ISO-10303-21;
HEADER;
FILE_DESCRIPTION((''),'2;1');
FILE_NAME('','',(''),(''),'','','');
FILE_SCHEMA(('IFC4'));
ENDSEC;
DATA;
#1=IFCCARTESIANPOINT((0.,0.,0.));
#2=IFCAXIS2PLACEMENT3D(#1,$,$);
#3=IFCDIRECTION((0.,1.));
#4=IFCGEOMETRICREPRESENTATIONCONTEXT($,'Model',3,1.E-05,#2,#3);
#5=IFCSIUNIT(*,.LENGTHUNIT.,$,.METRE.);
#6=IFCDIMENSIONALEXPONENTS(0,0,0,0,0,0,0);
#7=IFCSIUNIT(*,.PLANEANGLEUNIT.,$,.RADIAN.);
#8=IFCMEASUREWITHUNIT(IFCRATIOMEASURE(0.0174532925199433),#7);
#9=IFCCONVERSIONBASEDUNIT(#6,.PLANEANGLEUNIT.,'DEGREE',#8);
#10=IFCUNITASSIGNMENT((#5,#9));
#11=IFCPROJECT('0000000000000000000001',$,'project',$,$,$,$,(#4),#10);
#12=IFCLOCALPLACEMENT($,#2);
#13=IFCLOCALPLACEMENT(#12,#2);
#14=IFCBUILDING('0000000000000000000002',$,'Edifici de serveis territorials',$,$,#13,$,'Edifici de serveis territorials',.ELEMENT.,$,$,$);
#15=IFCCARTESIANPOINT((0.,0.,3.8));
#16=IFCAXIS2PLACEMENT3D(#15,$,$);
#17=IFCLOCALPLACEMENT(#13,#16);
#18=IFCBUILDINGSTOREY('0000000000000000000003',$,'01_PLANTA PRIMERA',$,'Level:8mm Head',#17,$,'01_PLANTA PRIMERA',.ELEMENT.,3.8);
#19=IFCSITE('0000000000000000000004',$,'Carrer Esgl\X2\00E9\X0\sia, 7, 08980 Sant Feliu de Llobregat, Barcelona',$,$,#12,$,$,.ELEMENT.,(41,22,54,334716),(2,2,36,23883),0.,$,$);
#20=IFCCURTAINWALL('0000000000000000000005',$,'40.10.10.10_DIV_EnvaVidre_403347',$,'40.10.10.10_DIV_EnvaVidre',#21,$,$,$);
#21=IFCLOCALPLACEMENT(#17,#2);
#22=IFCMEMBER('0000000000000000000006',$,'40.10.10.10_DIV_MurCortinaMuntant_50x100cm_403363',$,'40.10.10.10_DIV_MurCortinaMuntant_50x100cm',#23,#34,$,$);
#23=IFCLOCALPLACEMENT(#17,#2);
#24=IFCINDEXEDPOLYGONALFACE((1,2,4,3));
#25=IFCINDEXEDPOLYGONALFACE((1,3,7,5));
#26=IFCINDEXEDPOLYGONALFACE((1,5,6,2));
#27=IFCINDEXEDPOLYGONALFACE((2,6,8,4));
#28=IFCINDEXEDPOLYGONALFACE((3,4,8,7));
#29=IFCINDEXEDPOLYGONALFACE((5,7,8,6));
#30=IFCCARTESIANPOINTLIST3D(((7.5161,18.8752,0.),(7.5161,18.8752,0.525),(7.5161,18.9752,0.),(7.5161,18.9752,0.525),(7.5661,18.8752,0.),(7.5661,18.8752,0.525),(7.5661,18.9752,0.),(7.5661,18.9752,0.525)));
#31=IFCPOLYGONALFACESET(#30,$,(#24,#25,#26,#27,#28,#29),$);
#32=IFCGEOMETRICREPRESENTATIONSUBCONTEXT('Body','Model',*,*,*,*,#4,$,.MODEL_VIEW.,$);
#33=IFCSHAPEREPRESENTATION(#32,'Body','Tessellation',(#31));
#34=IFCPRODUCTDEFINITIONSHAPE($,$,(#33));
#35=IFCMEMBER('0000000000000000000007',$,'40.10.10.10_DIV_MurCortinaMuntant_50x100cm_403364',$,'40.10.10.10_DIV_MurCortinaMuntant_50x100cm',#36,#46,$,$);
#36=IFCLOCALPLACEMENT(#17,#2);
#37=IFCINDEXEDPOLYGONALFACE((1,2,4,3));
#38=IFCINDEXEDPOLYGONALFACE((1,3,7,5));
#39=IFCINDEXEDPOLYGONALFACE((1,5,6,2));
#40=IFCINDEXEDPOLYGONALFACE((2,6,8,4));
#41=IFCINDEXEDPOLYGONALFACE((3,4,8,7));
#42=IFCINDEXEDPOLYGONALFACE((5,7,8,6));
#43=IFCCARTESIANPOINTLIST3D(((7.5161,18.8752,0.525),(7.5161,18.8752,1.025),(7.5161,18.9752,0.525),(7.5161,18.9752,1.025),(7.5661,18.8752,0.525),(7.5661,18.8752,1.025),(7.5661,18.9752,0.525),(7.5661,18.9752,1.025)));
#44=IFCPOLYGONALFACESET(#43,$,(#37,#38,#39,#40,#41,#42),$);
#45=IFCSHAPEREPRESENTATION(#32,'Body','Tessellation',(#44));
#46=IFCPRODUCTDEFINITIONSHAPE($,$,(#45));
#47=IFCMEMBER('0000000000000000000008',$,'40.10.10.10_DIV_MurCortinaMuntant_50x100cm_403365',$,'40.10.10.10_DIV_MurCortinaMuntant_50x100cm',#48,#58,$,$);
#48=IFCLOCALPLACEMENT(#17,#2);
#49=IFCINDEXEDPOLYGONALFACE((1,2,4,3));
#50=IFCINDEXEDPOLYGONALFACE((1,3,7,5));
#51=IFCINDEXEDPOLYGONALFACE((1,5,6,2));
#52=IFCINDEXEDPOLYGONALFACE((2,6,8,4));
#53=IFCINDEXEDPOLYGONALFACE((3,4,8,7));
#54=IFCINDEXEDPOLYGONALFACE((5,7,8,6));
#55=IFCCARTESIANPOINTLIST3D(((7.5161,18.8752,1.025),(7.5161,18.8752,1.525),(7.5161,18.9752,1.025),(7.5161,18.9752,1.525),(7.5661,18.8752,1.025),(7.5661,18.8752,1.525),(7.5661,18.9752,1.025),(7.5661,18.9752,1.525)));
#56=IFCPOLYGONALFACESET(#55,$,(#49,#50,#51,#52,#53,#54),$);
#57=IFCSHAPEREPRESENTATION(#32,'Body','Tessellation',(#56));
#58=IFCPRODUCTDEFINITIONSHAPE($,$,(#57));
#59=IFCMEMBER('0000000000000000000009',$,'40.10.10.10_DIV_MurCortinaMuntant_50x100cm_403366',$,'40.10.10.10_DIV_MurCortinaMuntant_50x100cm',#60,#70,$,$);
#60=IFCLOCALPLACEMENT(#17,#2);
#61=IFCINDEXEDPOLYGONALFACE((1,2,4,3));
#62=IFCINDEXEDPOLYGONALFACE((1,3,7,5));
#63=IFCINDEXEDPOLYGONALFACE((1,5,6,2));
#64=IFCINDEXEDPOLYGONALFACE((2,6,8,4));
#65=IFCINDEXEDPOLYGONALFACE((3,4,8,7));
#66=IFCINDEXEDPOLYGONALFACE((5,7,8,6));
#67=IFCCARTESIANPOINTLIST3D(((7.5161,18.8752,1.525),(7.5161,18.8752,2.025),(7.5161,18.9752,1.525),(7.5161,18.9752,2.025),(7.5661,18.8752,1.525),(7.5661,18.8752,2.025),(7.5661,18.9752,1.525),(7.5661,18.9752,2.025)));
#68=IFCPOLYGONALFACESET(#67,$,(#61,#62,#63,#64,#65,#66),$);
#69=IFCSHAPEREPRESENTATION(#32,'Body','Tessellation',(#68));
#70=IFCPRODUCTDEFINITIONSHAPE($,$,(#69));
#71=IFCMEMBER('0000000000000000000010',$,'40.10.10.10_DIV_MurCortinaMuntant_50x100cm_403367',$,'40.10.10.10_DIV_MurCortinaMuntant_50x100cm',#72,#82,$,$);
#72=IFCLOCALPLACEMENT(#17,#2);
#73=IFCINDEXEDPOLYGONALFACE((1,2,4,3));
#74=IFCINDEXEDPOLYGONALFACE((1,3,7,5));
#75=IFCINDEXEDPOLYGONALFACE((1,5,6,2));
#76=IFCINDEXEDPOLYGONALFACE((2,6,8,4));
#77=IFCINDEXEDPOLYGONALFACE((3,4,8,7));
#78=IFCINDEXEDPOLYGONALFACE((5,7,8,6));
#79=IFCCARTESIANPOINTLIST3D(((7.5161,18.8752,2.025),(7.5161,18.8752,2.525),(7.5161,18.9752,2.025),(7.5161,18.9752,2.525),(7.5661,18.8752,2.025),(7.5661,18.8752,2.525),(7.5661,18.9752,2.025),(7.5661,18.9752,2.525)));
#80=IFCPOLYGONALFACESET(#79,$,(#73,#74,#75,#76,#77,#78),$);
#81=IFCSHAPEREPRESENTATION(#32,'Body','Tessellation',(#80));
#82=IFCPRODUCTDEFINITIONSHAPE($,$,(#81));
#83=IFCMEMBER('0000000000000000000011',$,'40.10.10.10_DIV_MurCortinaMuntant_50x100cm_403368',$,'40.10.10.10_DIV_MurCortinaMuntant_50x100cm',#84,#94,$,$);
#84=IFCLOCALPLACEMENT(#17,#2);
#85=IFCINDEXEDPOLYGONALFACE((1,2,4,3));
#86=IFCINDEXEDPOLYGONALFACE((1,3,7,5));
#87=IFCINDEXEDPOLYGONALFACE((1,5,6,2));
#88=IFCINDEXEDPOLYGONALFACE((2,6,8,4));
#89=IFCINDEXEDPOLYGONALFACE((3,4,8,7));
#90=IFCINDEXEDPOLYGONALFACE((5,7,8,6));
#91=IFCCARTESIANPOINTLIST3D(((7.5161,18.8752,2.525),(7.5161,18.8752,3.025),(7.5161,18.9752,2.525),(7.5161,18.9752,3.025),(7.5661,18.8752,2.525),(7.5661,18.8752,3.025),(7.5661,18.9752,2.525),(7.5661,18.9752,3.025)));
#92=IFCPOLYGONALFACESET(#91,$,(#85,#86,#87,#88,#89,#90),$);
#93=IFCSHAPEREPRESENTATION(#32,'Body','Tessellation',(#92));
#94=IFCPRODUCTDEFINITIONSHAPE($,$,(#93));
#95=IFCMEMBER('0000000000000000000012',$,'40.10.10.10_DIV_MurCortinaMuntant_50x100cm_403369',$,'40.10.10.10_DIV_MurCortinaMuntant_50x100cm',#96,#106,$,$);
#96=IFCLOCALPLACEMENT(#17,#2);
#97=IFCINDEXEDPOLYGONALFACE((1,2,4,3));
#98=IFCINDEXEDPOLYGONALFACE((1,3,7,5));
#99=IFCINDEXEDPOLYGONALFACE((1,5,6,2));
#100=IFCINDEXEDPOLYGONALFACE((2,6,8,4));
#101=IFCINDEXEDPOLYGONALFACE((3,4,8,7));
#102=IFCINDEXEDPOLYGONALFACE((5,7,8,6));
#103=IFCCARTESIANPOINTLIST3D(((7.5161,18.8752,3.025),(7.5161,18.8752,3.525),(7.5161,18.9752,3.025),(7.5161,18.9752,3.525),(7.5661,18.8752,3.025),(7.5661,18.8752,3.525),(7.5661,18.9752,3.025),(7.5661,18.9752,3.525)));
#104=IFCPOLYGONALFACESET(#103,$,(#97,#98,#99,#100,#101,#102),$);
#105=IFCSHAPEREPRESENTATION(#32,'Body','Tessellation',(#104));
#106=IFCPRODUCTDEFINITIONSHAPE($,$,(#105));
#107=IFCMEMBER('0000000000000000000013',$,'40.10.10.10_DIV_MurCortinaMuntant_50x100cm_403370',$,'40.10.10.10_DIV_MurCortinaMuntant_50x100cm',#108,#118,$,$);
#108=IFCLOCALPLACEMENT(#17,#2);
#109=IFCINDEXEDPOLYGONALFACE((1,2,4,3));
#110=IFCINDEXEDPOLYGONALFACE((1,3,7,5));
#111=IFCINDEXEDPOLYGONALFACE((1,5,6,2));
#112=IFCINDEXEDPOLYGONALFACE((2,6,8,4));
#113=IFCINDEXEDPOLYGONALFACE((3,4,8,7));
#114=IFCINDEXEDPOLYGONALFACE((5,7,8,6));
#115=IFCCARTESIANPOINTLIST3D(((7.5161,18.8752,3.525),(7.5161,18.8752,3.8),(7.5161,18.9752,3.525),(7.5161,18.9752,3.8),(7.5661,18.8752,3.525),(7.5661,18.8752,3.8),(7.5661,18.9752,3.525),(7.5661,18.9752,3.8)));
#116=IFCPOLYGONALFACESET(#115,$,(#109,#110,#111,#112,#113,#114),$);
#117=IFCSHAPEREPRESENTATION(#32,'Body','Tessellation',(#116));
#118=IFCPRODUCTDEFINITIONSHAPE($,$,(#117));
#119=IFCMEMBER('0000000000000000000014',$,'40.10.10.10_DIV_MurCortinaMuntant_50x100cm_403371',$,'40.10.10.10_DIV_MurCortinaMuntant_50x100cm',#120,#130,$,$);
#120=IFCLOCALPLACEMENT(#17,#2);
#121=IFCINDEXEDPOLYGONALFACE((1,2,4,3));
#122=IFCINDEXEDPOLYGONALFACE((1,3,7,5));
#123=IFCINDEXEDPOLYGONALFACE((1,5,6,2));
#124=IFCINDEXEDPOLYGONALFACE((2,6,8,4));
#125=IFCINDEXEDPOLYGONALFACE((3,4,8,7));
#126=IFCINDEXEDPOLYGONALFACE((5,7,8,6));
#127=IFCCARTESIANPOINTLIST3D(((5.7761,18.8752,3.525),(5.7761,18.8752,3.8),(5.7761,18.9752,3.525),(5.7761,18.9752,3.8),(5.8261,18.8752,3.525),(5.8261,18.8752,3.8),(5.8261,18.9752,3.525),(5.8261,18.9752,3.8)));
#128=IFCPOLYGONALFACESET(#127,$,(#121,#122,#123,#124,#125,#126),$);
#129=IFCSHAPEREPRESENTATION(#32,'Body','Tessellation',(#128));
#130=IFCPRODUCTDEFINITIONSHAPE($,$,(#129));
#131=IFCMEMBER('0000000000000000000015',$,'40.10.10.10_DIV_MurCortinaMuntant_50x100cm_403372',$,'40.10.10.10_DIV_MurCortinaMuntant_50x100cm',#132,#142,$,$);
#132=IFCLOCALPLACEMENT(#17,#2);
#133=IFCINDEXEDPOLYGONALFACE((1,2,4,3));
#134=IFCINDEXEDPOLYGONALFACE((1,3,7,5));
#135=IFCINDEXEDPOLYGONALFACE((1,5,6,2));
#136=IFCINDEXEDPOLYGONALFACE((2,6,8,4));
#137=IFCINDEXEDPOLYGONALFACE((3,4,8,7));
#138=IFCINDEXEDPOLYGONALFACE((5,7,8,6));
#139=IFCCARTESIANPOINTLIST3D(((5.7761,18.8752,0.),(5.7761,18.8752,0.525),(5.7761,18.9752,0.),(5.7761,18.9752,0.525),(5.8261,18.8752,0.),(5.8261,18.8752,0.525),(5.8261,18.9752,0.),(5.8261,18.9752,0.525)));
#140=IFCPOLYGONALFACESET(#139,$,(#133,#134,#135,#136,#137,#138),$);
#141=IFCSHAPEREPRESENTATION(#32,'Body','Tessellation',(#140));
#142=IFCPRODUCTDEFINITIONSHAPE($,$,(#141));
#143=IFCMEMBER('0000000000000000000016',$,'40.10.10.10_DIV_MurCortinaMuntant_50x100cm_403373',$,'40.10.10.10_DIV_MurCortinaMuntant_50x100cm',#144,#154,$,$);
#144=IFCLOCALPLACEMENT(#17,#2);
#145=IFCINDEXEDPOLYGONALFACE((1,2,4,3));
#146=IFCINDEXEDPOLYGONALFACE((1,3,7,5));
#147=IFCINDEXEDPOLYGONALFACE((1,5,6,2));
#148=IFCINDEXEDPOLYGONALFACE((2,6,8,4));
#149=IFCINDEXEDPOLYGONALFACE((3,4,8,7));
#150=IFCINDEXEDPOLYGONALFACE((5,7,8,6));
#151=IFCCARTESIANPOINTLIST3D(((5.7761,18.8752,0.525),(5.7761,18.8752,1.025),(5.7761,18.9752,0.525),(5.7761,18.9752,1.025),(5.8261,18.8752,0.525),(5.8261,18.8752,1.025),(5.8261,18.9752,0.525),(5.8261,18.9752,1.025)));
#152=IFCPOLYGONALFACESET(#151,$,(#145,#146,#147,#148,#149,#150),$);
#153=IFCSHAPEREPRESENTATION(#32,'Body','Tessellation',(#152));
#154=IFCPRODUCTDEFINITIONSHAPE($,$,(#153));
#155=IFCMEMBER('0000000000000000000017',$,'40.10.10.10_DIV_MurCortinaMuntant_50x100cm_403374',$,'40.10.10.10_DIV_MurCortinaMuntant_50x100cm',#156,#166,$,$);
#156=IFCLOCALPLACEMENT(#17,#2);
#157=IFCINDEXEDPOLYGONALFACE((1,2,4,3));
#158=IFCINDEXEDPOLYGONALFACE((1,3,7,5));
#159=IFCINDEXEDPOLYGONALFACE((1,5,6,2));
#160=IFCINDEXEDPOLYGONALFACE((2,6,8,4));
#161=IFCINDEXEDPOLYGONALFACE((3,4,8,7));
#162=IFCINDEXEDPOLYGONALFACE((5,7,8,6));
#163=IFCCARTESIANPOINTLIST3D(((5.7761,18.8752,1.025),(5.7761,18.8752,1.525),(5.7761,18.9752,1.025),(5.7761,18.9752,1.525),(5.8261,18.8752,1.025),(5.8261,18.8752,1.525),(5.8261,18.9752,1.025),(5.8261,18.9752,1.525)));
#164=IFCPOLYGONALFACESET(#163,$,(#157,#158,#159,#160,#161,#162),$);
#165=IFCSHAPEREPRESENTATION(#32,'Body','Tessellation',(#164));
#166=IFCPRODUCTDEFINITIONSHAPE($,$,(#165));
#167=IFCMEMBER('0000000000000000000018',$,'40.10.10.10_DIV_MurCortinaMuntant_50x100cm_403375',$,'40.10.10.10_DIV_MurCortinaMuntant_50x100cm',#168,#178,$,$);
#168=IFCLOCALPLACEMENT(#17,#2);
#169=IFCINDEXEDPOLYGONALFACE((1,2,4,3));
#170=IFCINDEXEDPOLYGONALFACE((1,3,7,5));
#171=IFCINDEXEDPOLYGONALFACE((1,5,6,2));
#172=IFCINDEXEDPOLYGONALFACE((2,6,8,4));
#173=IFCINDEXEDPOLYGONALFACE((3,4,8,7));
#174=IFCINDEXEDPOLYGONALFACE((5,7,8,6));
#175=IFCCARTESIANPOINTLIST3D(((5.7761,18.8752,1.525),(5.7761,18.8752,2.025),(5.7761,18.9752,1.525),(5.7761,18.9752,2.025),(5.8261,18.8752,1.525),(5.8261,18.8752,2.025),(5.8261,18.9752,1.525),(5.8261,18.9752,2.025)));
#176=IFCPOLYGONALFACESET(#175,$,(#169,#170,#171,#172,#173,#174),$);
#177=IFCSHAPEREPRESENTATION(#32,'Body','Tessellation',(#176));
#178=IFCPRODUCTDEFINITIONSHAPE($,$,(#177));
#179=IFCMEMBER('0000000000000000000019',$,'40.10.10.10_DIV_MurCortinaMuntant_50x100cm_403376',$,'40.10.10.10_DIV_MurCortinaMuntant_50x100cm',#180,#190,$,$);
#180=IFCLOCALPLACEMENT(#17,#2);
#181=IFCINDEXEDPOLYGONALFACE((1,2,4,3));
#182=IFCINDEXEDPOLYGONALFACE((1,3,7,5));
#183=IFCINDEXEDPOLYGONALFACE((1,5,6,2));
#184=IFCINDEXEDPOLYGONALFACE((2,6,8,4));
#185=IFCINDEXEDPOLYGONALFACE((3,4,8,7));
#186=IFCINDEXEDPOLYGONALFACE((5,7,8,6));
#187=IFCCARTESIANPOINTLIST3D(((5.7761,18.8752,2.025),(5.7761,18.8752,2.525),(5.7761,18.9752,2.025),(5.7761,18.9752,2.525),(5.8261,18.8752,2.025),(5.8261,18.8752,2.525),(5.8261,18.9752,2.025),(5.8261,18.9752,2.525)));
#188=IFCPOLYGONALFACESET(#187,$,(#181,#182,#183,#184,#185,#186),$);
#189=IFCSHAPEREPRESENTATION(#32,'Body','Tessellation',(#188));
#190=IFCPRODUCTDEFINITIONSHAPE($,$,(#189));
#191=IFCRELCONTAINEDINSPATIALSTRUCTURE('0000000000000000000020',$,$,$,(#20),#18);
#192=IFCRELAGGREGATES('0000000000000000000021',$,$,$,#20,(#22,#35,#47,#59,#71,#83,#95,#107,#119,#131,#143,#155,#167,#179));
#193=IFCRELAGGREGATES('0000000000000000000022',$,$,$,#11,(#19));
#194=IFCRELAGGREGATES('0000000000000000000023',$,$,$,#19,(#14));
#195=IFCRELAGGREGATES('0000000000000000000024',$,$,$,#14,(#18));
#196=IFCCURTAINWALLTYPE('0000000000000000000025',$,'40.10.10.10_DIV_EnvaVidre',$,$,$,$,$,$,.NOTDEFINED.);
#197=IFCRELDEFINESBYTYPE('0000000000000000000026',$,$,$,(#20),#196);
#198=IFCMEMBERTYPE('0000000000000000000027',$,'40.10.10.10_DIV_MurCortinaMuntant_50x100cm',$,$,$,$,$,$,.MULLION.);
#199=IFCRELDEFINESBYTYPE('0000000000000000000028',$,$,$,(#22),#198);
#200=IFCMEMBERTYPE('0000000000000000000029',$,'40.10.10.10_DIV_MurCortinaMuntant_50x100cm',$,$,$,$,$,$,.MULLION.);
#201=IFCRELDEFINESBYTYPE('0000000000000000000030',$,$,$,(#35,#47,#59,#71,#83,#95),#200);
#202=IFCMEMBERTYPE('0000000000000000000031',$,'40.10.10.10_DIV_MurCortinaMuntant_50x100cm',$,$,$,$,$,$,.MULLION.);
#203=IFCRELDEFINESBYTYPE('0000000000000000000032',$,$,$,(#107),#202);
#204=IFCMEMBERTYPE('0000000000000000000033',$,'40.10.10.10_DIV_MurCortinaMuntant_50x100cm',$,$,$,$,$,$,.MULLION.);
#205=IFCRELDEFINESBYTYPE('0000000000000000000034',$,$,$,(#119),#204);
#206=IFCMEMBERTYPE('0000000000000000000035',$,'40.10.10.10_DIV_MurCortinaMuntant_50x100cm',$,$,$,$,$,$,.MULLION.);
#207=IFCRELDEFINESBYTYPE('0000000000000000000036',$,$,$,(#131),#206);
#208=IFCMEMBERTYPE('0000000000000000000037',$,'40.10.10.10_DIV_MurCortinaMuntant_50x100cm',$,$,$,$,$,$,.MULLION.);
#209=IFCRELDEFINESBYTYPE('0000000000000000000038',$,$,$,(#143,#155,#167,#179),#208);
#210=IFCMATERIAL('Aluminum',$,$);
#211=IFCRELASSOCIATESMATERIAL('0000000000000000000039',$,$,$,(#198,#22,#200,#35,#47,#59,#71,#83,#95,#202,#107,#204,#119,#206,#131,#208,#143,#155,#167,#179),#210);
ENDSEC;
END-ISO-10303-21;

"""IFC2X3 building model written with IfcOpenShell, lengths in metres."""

from ifc_helpers import new_model, entity, si_unit, converted_unit, direction, frame, origin, origin_2d_with_axis, place, context, subcontext, project, spatial, rectangle, extrude, source, transform, mapped, material, type_object, type_shapes, element, aggregate, save


model = new_model("IFC2X3")

# Units and contexts
model_context = context("Model", 3, precision=1e-05, world=origin(), true_north=direction((0.0, 1.0)))
body_context = subcontext(model_context, "Body", "Model", "MODEL_VIEW")
ifc_project = project(units=[si_unit("LENGTHUNIT", "METRE"), converted_unit("PLANEANGLEUNIT", "DEGREE", entity("IfcRatioMeasure", 0.0174532925199433), si_unit("PLANEANGLEUNIT", "RADIAN"), dimensions=[0, 0, 0, 0, 0, 0, 0])], contexts=[model_context])

# Site, building, storey
site_placement = place(None, origin())
site = spatial("IfcSite", under=ifc_project, at=site_placement, Name="Carrer Església, 7, 08980 Sant Feliu de Llobregat, Barcelona", CompositionType="ELEMENT", RefLatitude=(41, 22, 54, 334716), RefLongitude=(2, 2, 36, 23883), RefElevation=0.0)
building_placement = place(site_placement, origin())
building = spatial("IfcBuilding", under=site, at=building_placement, Name="Edifici de serveis territorials", LongName="Edifici de serveis territorials", CompositionType="ELEMENT")
storey_placement = place(building_placement, frame((0.0, 0.0, 3.8)))
storey = spatial("IfcBuildingStorey", under=building, at=storey_placement, Name="01_PLANTA PRIMERA", ObjectType="Level:8mm Head", LongName="01_PLANTA PRIMERA", CompositionType="ELEMENT", Elevation=3.8)

# Curtain wall, members
curtain_wall_type = type_object("IfcCurtainWallType", Name="40.10.10.10_DIV_EnvaVidre", PredefinedType="NOTDEFINED")
curtain_wall_1_placement = place(storey_placement, frame((0.0, 0.0, -3.8)))
curtain_wall_1 = element("IfcCurtainWall", 1, at=curtain_wall_1_placement, inside=storey, type_object=curtain_wall_type, Name="40.10.10.10_DIV_EnvaVidre_403347", ObjectType="40.10.10.10_DIV_EnvaVidre")
ifc_material_1 = material(Name="Aluminum")
member_type_1 = type_object("IfcMemberType", Name="40.10.10.10_DIV_MurCortinaMuntant_50x100cm", PredefinedType="MULLION", material=ifc_material_1)
shared_shape_1 = source(origin(), body_context, "Body", "SweptSolid", [
    extrude(rectangle(XDim=0.1, YDim=0.05, at=origin_2d_with_axis()), frame((-0.025, 0.0, -0.525), z_axis=(0.0, 0.0, 1.0), x_axis=(0.0, -1.0, 0.0)), (0.0, 0.0, 1.0), 0.525),
])
type_shapes(member_type_1, [shared_shape_1])
member_1_placement = place(storey_placement, frame((7.5661, 18.9252, 0.0), z_axis=(0.0, 0.0, -1.0), x_axis=(1.0, 0.0, 0.0)))
member_1 = element("IfcMember", 2, at=member_1_placement, type_object=member_type_1, material=ifc_material_1, Name="40.10.10.10_DIV_MurCortinaMuntant_50x100cm_403363", ObjectType="40.10.10.10_DIV_MurCortinaMuntant_50x100cm", context=body_context, shape_type="MappedRepresentation", body=[
    mapped(shared_shape_1, transform((0.0, 0.0, 0.0), scale=1.0)),
])
member_type_2 = type_object("IfcMemberType", Name="40.10.10.10_DIV_MurCortinaMuntant_50x100cm", PredefinedType="MULLION", material=ifc_material_1)
shared_shape_2 = source(origin(), body_context, "Body", "SweptSolid", [
    extrude(rectangle(XDim=0.1, YDim=0.05, at=origin_2d_with_axis()), frame((-0.025, 0.0, -0.5), z_axis=(0.0, 0.0, 1.0), x_axis=(0.0, -1.0, 0.0)), (0.0, 0.0, 1.0), 0.5),
])
type_shapes(member_type_2, [shared_shape_2])
member_2_placement = place(storey_placement, frame((7.5661, 18.9252, 0.525), z_axis=(0.0, 0.0, -1.0), x_axis=(1.0, 0.0, 0.0)))
member_2 = element("IfcMember", 3, at=member_2_placement, type_object=member_type_2, material=ifc_material_1, Name="40.10.10.10_DIV_MurCortinaMuntant_50x100cm_403364", ObjectType="40.10.10.10_DIV_MurCortinaMuntant_50x100cm", context=body_context, shape_type="MappedRepresentation", body=[
    mapped(shared_shape_2, transform((0.0, 0.0, 0.0), scale=1.0)),
])
member_3_placement = place(storey_placement, frame((7.5661, 18.9252, 1.025), z_axis=(0.0, 0.0, -1.0), x_axis=(1.0, 0.0, 0.0)))
member_3 = element("IfcMember", 4, at=member_3_placement, type_object=member_type_2, material=ifc_material_1, Name="40.10.10.10_DIV_MurCortinaMuntant_50x100cm_403365", ObjectType="40.10.10.10_DIV_MurCortinaMuntant_50x100cm", context=body_context, shape_type="MappedRepresentation", body=[
    mapped(shared_shape_2, transform((0.0, 0.0, 0.0), scale=1.0)),
])
member_4_placement = place(storey_placement, frame((7.5661, 18.9252, 1.525), z_axis=(0.0, 0.0, -1.0), x_axis=(1.0, 0.0, 0.0)))
member_4 = element("IfcMember", 5, at=member_4_placement, type_object=member_type_2, material=ifc_material_1, Name="40.10.10.10_DIV_MurCortinaMuntant_50x100cm_403366", ObjectType="40.10.10.10_DIV_MurCortinaMuntant_50x100cm", context=body_context, shape_type="MappedRepresentation", body=[
    mapped(shared_shape_2, transform((0.0, 0.0, 0.0), scale=1.0)),
])
member_5_placement = place(storey_placement, frame((7.5661, 18.9252, 2.025), z_axis=(0.0, 0.0, -1.0), x_axis=(1.0, 0.0, 0.0)))
member_5 = element("IfcMember", 6, at=member_5_placement, type_object=member_type_2, material=ifc_material_1, Name="40.10.10.10_DIV_MurCortinaMuntant_50x100cm_403367", ObjectType="40.10.10.10_DIV_MurCortinaMuntant_50x100cm", context=body_context, shape_type="MappedRepresentation", body=[
    mapped(shared_shape_2, transform((0.0, 0.0, 0.0), scale=1.0)),
])
member_6_placement = place(storey_placement, frame((7.5661, 18.9252, 2.525), z_axis=(0.0, 0.0, -1.0), x_axis=(1.0, 0.0, 0.0)))
member_6 = element("IfcMember", 7, at=member_6_placement, type_object=member_type_2, material=ifc_material_1, Name="40.10.10.10_DIV_MurCortinaMuntant_50x100cm_403368", ObjectType="40.10.10.10_DIV_MurCortinaMuntant_50x100cm", context=body_context, shape_type="MappedRepresentation", body=[
    mapped(shared_shape_2, transform((0.0, 0.0, 0.0), scale=1.0)),
])
member_7_placement = place(storey_placement, frame((7.5661, 18.9252, 3.025), z_axis=(0.0, 0.0, -1.0), x_axis=(1.0, 0.0, 0.0)))
member_7 = element("IfcMember", 8, at=member_7_placement, type_object=member_type_2, material=ifc_material_1, Name="40.10.10.10_DIV_MurCortinaMuntant_50x100cm_403369", ObjectType="40.10.10.10_DIV_MurCortinaMuntant_50x100cm", context=body_context, shape_type="MappedRepresentation", body=[
    mapped(shared_shape_2, transform((0.0, 0.0, 0.0), scale=1.0)),
])
member_type_3 = type_object("IfcMemberType", Name="40.10.10.10_DIV_MurCortinaMuntant_50x100cm", PredefinedType="MULLION", material=ifc_material_1)
shared_shape_3 = source(origin(), body_context, "Body", "SweptSolid", [
    extrude(rectangle(XDim=0.1, YDim=0.05, at=origin_2d_with_axis()), frame((-0.025, 0.0, -0.275), z_axis=(0.0, 0.0, 1.0), x_axis=(0.0, -1.0, 0.0)), (0.0, 0.0, 1.0), 0.275),
])
type_shapes(member_type_3, [shared_shape_3])
member_8_placement = place(storey_placement, frame((7.5661, 18.9252, 3.525), z_axis=(0.0, 0.0, -1.0), x_axis=(1.0, 0.0, 0.0)))
member_8 = element("IfcMember", 9, at=member_8_placement, type_object=member_type_3, material=ifc_material_1, Name="40.10.10.10_DIV_MurCortinaMuntant_50x100cm_403370", ObjectType="40.10.10.10_DIV_MurCortinaMuntant_50x100cm", context=body_context, shape_type="MappedRepresentation", body=[
    mapped(shared_shape_3, transform((0.0, 0.0, 0.0), scale=1.0)),
])
member_type_4 = type_object("IfcMemberType", Name="40.10.10.10_DIV_MurCortinaMuntant_50x100cm", PredefinedType="MULLION", material=ifc_material_1)
shared_shape_4 = source(origin(), body_context, "Body", "SweptSolid", [
    extrude(rectangle(XDim=0.1, YDim=0.05, at=origin_2d_with_axis()), frame((-0.025, 0.0, -0.275), z_axis=(0.0, 0.0, 1.0), x_axis=(0.0, -1.0, 0.0)), (0.0, 0.0, 1.0), 0.275),
])
type_shapes(member_type_4, [shared_shape_4])
member_9_placement = place(storey_placement, frame((5.7761, 18.9252, 3.8), z_axis=(0.0, 0.0, 1.0), x_axis=(-1.0, 0.0, 0.0)))
member_9 = element("IfcMember", 10, at=member_9_placement, type_object=member_type_4, material=ifc_material_1, Name="40.10.10.10_DIV_MurCortinaMuntant_50x100cm_403371", ObjectType="40.10.10.10_DIV_MurCortinaMuntant_50x100cm", context=body_context, shape_type="MappedRepresentation", body=[
    mapped(shared_shape_4, transform((0.0, 0.0, 0.0), scale=1.0)),
])
member_type_5 = type_object("IfcMemberType", Name="40.10.10.10_DIV_MurCortinaMuntant_50x100cm", PredefinedType="MULLION", material=ifc_material_1)
shared_shape_5 = source(origin(), body_context, "Body", "SweptSolid", [
    extrude(rectangle(XDim=0.1, YDim=0.05, at=origin_2d_with_axis()), frame((-0.025, 0.0, -0.525), z_axis=(0.0, 0.0, 1.0), x_axis=(0.0, -1.0, 0.0)), (0.0, 0.0, 1.0), 0.525),
])
type_shapes(member_type_5, [shared_shape_5])
member_10_placement = place(storey_placement, frame((5.7761, 18.9252, 0.525), z_axis=(0.0, 0.0, 1.0), x_axis=(-1.0, 0.0, 0.0)))
member_10 = element("IfcMember", 11, at=member_10_placement, type_object=member_type_5, material=ifc_material_1, Name="40.10.10.10_DIV_MurCortinaMuntant_50x100cm_403372", ObjectType="40.10.10.10_DIV_MurCortinaMuntant_50x100cm", context=body_context, shape_type="MappedRepresentation", body=[
    mapped(shared_shape_5, transform((0.0, 0.0, 0.0), scale=1.0)),
])
member_type_6 = type_object("IfcMemberType", Name="40.10.10.10_DIV_MurCortinaMuntant_50x100cm", PredefinedType="MULLION", material=ifc_material_1)
shared_shape_6 = source(origin(), body_context, "Body", "SweptSolid", [
    extrude(rectangle(XDim=0.1, YDim=0.05, at=origin_2d_with_axis()), frame((-0.025, 0.0, -0.5), z_axis=(0.0, 0.0, 1.0), x_axis=(0.0, -1.0, 0.0)), (0.0, 0.0, 1.0), 0.5),
])
type_shapes(member_type_6, [shared_shape_6])
member_11_placement = place(storey_placement, frame((5.7761, 18.9252, 1.025), z_axis=(0.0, 0.0, 1.0), x_axis=(-1.0, 0.0, 0.0)))
member_11 = element("IfcMember", 12, at=member_11_placement, type_object=member_type_6, material=ifc_material_1, Name="40.10.10.10_DIV_MurCortinaMuntant_50x100cm_403373", ObjectType="40.10.10.10_DIV_MurCortinaMuntant_50x100cm", context=body_context, shape_type="MappedRepresentation", body=[
    mapped(shared_shape_6, transform((0.0, 0.0, 0.0), scale=1.0)),
])
member_12_placement = place(storey_placement, frame((5.7761, 18.9252, 1.525), z_axis=(0.0, 0.0, 1.0), x_axis=(-1.0, 0.0, 0.0)))
member_12 = element("IfcMember", 13, at=member_12_placement, type_object=member_type_6, material=ifc_material_1, Name="40.10.10.10_DIV_MurCortinaMuntant_50x100cm_403374", ObjectType="40.10.10.10_DIV_MurCortinaMuntant_50x100cm", context=body_context, shape_type="MappedRepresentation", body=[
    mapped(shared_shape_6, transform((0.0, 0.0, 0.0), scale=1.0)),
])
member_13_placement = place(storey_placement, frame((5.7761, 18.9252, 2.025), z_axis=(0.0, 0.0, 1.0), x_axis=(-1.0, 0.0, 0.0)))
member_13 = element("IfcMember", 14, at=member_13_placement, type_object=member_type_6, material=ifc_material_1, Name="40.10.10.10_DIV_MurCortinaMuntant_50x100cm_403375", ObjectType="40.10.10.10_DIV_MurCortinaMuntant_50x100cm", context=body_context, shape_type="MappedRepresentation", body=[
    mapped(shared_shape_6, transform((0.0, 0.0, 0.0), scale=1.0)),
])
member_14_placement = place(storey_placement, frame((5.7761, 18.9252, 2.525), z_axis=(0.0, 0.0, 1.0), x_axis=(-1.0, 0.0, 0.0)))
member_14 = element("IfcMember", 15, at=member_14_placement, type_object=member_type_6, material=ifc_material_1, Name="40.10.10.10_DIV_MurCortinaMuntant_50x100cm_403376", ObjectType="40.10.10.10_DIV_MurCortinaMuntant_50x100cm", context=body_context, shape_type="MappedRepresentation", body=[
    mapped(shared_shape_6, transform((0.0, 0.0, 0.0), scale=1.0)),
])
aggregate(curtain_wall_1, [member_1, member_2, member_3, member_4, member_5, member_6, member_7, member_8, member_9, member_10, member_11, member_12, member_13, member_14])

save(model, "model.ifc")
